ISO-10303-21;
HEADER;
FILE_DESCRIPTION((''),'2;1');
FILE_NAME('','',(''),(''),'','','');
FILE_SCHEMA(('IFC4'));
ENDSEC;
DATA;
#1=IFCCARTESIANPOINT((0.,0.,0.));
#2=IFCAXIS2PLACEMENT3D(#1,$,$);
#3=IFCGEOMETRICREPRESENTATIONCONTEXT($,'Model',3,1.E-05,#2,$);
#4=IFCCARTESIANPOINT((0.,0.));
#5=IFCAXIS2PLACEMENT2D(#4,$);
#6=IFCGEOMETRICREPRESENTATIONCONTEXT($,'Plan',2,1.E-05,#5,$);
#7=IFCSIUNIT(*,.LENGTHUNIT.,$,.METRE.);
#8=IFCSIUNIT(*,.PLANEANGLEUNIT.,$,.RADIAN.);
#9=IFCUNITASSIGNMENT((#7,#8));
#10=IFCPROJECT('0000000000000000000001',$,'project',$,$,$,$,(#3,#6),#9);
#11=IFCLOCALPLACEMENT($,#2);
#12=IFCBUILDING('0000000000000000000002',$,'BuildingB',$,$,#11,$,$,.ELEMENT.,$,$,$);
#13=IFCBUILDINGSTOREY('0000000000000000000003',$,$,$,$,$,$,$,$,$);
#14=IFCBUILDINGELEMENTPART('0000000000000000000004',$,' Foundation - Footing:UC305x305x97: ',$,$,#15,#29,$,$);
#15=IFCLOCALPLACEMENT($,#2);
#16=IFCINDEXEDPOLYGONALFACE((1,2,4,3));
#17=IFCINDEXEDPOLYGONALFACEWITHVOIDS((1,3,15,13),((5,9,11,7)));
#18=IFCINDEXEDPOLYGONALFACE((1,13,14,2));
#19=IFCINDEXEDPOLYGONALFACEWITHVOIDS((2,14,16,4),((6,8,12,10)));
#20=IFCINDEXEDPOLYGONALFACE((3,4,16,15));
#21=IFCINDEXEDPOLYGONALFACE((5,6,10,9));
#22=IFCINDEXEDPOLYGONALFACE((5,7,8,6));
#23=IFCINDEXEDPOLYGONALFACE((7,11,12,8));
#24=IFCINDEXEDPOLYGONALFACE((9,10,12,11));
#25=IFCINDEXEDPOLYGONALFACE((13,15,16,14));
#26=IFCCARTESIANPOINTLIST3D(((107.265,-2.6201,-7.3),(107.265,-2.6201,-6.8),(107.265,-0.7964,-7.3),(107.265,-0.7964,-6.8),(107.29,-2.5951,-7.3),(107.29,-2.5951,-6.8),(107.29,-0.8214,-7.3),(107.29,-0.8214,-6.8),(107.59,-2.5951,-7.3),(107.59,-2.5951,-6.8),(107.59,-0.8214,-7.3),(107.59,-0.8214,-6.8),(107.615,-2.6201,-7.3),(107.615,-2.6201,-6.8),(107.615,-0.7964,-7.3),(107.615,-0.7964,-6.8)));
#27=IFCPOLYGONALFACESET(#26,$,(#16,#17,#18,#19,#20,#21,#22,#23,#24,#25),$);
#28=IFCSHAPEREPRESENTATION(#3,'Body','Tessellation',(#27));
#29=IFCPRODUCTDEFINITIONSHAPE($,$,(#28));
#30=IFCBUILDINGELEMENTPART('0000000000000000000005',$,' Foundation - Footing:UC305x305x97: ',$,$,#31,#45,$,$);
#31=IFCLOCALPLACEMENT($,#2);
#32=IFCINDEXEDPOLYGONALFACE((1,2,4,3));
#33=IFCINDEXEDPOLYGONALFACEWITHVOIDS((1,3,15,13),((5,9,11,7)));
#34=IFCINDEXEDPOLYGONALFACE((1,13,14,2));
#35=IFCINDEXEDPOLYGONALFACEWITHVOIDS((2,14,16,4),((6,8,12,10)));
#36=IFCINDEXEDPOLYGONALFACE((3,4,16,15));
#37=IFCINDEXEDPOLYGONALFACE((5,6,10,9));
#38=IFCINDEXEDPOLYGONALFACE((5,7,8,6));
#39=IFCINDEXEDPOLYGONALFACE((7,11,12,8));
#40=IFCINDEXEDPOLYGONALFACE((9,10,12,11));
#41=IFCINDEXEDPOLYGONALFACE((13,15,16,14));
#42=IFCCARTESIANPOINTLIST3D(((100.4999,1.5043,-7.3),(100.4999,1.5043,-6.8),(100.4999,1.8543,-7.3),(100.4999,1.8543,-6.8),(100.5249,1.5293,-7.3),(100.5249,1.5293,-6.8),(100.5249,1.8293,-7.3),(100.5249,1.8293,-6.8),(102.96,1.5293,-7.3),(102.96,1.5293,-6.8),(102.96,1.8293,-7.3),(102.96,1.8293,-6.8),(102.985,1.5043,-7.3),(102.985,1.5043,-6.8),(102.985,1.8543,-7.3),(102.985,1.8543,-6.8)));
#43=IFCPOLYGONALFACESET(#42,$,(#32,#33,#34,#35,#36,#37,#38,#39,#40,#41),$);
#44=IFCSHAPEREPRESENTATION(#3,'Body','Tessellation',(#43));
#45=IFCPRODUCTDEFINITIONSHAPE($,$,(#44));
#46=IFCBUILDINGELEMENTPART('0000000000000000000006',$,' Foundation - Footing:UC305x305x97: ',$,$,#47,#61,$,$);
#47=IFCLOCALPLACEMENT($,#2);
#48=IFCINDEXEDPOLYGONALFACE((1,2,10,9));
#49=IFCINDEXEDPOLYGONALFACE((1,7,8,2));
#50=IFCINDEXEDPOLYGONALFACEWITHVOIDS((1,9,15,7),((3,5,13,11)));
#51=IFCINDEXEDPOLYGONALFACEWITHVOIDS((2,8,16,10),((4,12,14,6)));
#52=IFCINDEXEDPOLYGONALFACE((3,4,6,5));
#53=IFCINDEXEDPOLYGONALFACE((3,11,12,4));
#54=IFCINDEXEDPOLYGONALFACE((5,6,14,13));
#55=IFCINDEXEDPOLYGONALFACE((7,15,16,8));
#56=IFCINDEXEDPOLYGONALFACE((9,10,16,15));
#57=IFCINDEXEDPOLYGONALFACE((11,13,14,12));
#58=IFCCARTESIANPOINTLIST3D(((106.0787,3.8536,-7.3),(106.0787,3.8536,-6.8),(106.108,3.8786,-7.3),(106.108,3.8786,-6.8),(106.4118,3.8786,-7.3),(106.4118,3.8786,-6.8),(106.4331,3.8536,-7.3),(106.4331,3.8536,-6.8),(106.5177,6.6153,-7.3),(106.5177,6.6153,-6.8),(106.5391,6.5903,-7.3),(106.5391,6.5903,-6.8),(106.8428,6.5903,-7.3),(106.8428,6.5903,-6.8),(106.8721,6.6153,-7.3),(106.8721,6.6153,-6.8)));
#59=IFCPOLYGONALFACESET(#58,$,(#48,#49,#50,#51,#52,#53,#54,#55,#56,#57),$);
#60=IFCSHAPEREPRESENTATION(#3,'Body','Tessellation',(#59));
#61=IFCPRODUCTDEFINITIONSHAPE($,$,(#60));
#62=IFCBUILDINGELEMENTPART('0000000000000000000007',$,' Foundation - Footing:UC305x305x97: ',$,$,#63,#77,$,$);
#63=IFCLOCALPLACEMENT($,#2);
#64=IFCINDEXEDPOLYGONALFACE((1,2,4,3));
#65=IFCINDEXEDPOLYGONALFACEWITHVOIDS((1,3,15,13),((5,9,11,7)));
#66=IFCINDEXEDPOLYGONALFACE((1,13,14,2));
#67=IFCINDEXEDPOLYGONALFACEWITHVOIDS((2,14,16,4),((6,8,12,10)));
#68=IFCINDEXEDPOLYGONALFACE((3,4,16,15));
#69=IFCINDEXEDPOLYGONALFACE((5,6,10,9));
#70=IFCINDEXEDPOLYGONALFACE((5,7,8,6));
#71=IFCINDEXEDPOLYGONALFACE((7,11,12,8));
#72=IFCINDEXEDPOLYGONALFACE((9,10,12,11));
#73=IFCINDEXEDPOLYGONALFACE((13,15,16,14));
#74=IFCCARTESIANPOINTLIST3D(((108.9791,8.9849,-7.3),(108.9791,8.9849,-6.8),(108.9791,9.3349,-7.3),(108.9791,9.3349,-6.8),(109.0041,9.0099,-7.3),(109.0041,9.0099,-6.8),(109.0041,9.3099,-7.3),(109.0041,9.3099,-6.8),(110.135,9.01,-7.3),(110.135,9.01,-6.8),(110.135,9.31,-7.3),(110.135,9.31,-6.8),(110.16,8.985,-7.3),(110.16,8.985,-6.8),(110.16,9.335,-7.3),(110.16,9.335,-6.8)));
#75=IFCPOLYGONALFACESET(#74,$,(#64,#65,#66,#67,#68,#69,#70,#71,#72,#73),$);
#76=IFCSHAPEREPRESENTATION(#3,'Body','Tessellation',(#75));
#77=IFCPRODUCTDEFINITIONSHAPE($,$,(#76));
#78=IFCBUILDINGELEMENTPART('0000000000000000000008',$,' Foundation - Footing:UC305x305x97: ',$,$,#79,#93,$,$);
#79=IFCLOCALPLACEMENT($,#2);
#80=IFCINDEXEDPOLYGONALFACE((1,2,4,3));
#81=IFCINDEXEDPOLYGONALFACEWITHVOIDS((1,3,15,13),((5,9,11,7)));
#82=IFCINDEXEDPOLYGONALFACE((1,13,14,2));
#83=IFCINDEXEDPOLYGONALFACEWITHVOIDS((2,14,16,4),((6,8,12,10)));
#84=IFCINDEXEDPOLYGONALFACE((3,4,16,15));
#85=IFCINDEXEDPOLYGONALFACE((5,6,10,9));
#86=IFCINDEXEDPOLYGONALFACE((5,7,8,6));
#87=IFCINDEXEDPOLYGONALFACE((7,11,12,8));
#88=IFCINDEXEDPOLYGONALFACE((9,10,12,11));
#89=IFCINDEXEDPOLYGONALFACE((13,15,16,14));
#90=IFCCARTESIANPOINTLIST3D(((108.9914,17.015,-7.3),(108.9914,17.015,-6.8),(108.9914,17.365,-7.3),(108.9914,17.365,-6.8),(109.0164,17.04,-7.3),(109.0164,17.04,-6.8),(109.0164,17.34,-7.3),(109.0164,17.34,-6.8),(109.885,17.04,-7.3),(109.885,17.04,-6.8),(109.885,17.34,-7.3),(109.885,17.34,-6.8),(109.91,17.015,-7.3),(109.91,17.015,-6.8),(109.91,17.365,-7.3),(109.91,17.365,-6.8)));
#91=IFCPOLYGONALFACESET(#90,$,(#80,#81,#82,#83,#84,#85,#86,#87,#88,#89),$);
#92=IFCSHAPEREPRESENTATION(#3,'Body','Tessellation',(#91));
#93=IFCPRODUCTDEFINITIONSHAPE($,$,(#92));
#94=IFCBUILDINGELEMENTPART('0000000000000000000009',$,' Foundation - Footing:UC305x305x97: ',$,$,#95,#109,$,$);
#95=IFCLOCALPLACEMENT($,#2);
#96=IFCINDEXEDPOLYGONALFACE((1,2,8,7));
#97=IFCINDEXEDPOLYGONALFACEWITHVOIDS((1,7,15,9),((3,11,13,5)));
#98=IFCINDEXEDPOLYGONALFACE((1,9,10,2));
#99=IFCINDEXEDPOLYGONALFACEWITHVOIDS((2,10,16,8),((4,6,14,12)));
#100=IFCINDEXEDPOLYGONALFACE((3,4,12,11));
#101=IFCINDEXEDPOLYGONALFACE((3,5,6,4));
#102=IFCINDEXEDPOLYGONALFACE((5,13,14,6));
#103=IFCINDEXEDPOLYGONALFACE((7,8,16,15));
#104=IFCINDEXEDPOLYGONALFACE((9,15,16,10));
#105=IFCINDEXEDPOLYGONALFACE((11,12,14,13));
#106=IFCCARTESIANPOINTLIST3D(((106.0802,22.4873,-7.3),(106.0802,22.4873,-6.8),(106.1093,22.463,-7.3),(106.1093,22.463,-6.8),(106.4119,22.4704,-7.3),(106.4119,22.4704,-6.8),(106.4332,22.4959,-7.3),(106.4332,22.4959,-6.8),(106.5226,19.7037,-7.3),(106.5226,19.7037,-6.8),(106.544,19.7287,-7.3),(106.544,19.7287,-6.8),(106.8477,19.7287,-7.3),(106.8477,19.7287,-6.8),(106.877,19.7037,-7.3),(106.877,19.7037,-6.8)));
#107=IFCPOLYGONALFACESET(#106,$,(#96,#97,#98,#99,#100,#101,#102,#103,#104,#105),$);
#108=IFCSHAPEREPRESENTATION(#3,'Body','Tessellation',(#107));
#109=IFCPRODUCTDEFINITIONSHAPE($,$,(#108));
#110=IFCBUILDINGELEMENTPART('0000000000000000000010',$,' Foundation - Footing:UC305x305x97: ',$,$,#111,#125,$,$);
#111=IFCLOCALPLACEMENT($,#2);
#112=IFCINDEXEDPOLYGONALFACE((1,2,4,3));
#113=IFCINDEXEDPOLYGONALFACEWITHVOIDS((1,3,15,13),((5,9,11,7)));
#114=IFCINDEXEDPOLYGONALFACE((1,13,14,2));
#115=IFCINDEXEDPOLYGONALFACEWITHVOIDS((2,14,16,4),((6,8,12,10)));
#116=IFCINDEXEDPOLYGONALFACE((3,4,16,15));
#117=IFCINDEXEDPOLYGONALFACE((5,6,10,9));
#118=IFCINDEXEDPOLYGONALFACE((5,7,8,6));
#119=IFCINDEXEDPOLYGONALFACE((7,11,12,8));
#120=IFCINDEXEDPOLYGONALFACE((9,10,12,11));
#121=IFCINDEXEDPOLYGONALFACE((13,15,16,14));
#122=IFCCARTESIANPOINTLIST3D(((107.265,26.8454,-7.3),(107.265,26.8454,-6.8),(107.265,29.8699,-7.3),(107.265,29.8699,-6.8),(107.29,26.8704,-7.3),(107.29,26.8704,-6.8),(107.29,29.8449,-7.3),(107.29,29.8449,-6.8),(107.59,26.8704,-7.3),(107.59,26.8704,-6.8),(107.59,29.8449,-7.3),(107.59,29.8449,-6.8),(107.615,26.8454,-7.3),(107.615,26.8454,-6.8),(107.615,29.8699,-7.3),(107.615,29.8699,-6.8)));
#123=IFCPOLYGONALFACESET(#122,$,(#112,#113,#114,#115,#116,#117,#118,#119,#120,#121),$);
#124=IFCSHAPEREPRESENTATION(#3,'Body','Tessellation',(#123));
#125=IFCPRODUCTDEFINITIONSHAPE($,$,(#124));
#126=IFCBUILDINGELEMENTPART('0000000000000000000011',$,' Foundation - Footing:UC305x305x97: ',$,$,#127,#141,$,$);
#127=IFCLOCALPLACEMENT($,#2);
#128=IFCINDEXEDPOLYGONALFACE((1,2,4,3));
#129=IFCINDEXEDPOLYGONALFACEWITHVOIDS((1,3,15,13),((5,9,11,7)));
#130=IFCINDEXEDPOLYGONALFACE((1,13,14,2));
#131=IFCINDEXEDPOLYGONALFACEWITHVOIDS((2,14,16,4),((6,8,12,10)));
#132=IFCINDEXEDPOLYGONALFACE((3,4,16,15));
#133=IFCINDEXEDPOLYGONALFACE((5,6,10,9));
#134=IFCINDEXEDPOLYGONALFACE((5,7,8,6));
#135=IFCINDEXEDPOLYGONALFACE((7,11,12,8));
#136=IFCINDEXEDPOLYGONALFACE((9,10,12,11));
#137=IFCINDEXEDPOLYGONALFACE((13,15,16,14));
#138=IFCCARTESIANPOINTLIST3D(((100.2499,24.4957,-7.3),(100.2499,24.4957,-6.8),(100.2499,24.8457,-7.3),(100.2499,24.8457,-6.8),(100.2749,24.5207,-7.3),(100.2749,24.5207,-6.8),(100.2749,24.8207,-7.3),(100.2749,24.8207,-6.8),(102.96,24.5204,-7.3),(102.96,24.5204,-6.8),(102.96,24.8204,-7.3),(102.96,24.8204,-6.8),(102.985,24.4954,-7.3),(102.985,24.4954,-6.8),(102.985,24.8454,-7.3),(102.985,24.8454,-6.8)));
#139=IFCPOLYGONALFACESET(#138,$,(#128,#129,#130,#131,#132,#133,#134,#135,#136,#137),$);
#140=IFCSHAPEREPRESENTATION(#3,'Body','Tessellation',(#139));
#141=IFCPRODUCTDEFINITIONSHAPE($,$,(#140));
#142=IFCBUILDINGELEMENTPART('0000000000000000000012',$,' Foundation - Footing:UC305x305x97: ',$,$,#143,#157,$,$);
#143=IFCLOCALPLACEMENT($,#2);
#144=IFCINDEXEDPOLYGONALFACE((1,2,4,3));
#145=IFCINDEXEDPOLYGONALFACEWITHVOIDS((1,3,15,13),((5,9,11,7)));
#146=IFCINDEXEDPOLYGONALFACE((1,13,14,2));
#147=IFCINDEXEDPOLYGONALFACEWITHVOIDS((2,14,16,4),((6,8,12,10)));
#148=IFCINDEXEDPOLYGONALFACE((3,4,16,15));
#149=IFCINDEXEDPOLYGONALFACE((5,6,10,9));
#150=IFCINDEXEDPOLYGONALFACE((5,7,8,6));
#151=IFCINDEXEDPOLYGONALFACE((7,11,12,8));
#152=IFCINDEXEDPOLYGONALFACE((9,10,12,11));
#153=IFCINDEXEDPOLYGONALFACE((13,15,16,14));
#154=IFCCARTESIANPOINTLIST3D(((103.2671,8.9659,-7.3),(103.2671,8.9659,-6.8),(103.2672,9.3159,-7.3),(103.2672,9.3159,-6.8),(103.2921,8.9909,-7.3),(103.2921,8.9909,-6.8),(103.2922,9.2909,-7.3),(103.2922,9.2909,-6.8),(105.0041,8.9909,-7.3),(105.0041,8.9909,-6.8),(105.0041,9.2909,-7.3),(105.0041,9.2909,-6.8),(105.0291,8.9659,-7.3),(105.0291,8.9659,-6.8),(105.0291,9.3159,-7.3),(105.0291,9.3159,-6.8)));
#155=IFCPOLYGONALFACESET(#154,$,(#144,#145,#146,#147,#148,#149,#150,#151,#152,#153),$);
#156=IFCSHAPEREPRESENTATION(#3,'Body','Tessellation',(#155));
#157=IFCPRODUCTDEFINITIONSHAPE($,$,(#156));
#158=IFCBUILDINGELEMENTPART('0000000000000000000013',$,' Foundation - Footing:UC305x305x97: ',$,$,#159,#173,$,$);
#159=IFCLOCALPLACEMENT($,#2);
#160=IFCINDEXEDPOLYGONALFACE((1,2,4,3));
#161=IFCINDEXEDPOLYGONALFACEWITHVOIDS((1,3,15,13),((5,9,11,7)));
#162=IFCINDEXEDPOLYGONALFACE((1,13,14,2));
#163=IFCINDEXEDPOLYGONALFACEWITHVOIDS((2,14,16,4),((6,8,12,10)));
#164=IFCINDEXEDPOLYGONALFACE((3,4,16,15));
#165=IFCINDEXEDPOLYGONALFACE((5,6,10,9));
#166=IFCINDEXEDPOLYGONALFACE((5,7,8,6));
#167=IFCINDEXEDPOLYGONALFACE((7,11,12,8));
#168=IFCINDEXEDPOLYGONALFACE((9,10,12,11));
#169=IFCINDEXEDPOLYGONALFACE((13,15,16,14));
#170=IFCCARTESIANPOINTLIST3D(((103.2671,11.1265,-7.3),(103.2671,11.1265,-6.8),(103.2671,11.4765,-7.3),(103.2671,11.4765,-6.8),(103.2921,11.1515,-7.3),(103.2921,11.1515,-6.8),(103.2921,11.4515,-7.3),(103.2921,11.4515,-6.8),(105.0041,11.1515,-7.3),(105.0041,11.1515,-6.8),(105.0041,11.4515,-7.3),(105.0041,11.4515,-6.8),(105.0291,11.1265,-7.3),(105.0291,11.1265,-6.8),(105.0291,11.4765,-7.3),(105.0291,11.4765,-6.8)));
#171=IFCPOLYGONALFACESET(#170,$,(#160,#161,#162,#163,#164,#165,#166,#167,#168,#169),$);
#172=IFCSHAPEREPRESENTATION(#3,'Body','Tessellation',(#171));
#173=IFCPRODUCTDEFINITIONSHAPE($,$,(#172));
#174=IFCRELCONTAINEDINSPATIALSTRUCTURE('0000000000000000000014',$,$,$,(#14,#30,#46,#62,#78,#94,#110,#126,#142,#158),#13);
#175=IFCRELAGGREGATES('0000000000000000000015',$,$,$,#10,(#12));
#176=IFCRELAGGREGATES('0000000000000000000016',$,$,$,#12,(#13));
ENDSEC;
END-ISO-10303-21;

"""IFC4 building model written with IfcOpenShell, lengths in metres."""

from ifc_helpers import new_model, si_unit, origin, origin_2d, place, context, project, spatial, polyline, outline, extrude, element, save


model = new_model("IFC4")

# Units and contexts
model_context = context("Model", 3, precision=1e-05, world=origin())
plan_context = context("Plan", 2, precision=1e-05, world=origin_2d())
ifc_project = project(units=[si_unit("LENGTHUNIT", "METRE"), si_unit("PLANEANGLEUNIT", "RADIAN")], contexts=[model_context, plan_context])

# Building, storey
building_placement = place(None, origin())
building = spatial("IfcBuilding", under=ifc_project, at=building_placement, Name="BuildingB", CompositionType="ELEMENT")
storey = spatial("IfcBuildingStorey", under=building)

# Building element parts, openings
building_element_part_1 = element("IfcBuildingElementPart", 1, inside=storey, Name=" Foundation - Footing:UC305x305x97: ", context=model_context, shape_type="SweptSolid", body=[
    extrude(outline(polyline([(107.615, -2.6201, -7.3), (107.265, -2.6201, -7.3), (107.265, -0.7964, -7.3), (107.615, -0.7964, -7.3), (107.615, -2.6201, -7.3)])), None, (0.0, 0.0, 1.0), 0.5),
])
element("IfcOpeningElement", 2, inside=storey, cuts=building_element_part_1, context=model_context, shape_type="SweptSolid", body=[
    extrude(outline(polyline([(107.59, -2.5951, -7.3), (107.29, -2.5951, -7.3), (107.29, -0.8214, -7.3), (107.59, -0.8214, -7.3), (107.59, -2.5951, -7.3)])), None, (0.0, 0.0, 1.0), 0.5),
])
building_element_part_2 = element("IfcBuildingElementPart", 3, inside=storey, Name=" Foundation - Footing:UC305x305x97: ", context=model_context, shape_type="SweptSolid", body=[
    extrude(outline(polyline([(102.985, 1.5043, -7.3), (102.985, 1.8543, -7.3), (100.4999, 1.8543, -7.3), (100.4999, 1.5043, -7.3), (102.985, 1.5043, -7.3)])), None, (0.0, 0.0, 1.0), 0.5),
])
element("IfcOpeningElement", 4, inside=storey, cuts=building_element_part_2, context=model_context, shape_type="SweptSolid", body=[
    extrude(outline(polyline([(102.96, 1.5293, -7.3), (102.96, 1.8293, -7.3), (100.5249, 1.8293, -7.3), (100.5249, 1.5293, -7.3), (102.96, 1.5293, -7.3)])), None, (0.0, 0.0, 1.0), 0.5),
])
building_element_part_3 = element("IfcBuildingElementPart", 5, inside=storey, Name=" Foundation - Footing:UC305x305x97: ", context=model_context, shape_type="SweptSolid", body=[
    extrude(outline(polyline([(106.4331, 3.8536, -7.3), (106.8721, 6.6153, -7.3), (106.5177, 6.6153, -7.3), (106.0787, 3.8536, -7.3), (106.4331, 3.8536, -7.3)])), None, (0.0, 0.0, 1.0), 0.5),
])
element("IfcOpeningElement", 6, inside=storey, cuts=building_element_part_3, context=model_context, shape_type="SweptSolid", body=[
    extrude(outline(polyline([(106.4118, 3.8786, -7.3), (106.8428, 6.5903, -7.3), (106.5391, 6.5903, -7.3), (106.108, 3.8786, -7.3), (106.4118, 3.8786, -7.3)])), None, (0.0, 0.0, 1.0), 0.5),
])
building_element_part_4 = element("IfcBuildingElementPart", 7, inside=storey, Name=" Foundation - Footing:UC305x305x97: ", context=model_context, shape_type="SweptSolid", body=[
    extrude(outline(polyline([(110.16, 8.985, -7.3), (110.16, 9.335, -7.3), (108.9791, 9.3349, -7.3), (108.9791, 8.9849, -7.3), (110.16, 8.985, -7.3)])), None, (0.0, 0.0, 1.0), 0.5),
])
element("IfcOpeningElement", 8, inside=storey, cuts=building_element_part_4, context=model_context, shape_type="SweptSolid", body=[
    extrude(outline(polyline([(110.135, 9.01, -7.3), (110.135, 9.31, -7.3), (109.0041, 9.3099, -7.3), (109.0041, 9.0099, -7.3), (110.135, 9.01, -7.3)])), None, (0.0, 0.0, 1.0), 0.5),
])
building_element_part_5 = element("IfcBuildingElementPart", 9, inside=storey, Name=" Foundation - Footing:UC305x305x97: ", context=model_context, shape_type="SweptSolid", body=[
    extrude(outline(polyline([(109.91, 17.015, -7.3), (109.91, 17.365, -7.3), (108.9914, 17.365, -7.3), (108.9914, 17.015, -7.3), (109.91, 17.015, -7.3)])), None, (0.0, 0.0, 1.0), 0.5),
])
element("IfcOpeningElement", 10, inside=storey, cuts=building_element_part_5, context=model_context, shape_type="SweptSolid", body=[
    extrude(outline(polyline([(109.885, 17.04, -7.3), (109.885, 17.34, -7.3), (109.0164, 17.34, -7.3), (109.0164, 17.04, -7.3), (109.885, 17.04, -7.3)])), None, (0.0, 0.0, 1.0), 0.5),
])
building_element_part_6 = element("IfcBuildingElementPart", 11, inside=storey, Name=" Foundation - Footing:UC305x305x97: ", context=model_context, shape_type="SweptSolid", body=[
    extrude(outline(polyline([(106.5226, 19.7037, -7.3), (106.877, 19.7037, -7.3), (106.4332, 22.4959, -7.3), (106.0802, 22.4873, -7.3), (106.5226, 19.7037, -7.3)])), None, (0.0, 0.0, 1.0), 0.5),
])
element("IfcOpeningElement", 12, inside=storey, cuts=building_element_part_6, context=model_context, shape_type="SweptSolid", body=[
    extrude(outline(polyline([(106.544, 19.7287, -7.3), (106.8477, 19.7287, -7.3), (106.4119, 22.4704, -7.3), (106.1093, 22.463, -7.3), (106.544, 19.7287, -7.3)])), None, (0.0, 0.0, 1.0), 0.5),
])
building_element_part_7 = element("IfcBuildingElementPart", 13, inside=storey, Name=" Foundation - Footing:UC305x305x97: ", context=model_context, shape_type="SweptSolid", body=[
    extrude(outline(polyline([(107.265, 26.8454, -7.3), (107.615, 26.8454, -7.3), (107.615, 29.8699, -7.3), (107.265, 29.8699, -7.3), (107.265, 26.8454, -7.3)])), None, (0.0, 0.0, 1.0), 0.5),
])
element("IfcOpeningElement", 14, inside=storey, cuts=building_element_part_7, context=model_context, shape_type="SweptSolid", body=[
    extrude(outline(polyline([(107.29, 26.8704, -7.3), (107.59, 26.8704, -7.3), (107.59, 29.8449, -7.3), (107.29, 29.8449, -7.3), (107.29, 26.8704, -7.3)])), None, (0.0, 0.0, 1.0), 0.5),
])
building_element_part_8 = element("IfcBuildingElementPart", 15, inside=storey, Name=" Foundation - Footing:UC305x305x97: ", context=model_context, shape_type="SweptSolid", body=[
    extrude(outline(polyline([(102.985, 24.4954, -7.3), (102.985, 24.8454, -7.3), (100.2499, 24.8457, -7.3), (100.2499, 24.4957, -7.3), (102.985, 24.4954, -7.3)])), None, (0.0, 0.0, 1.0), 0.5),
])
element("IfcOpeningElement", 16, inside=storey, cuts=building_element_part_8, context=model_context, shape_type="SweptSolid", body=[
    extrude(outline(polyline([(102.96, 24.5204, -7.3), (102.96, 24.8204, -7.3), (100.2749, 24.8207, -7.3), (100.2749, 24.5207, -7.3), (102.96, 24.5204, -7.3)])), None, (0.0, 0.0, 1.0), 0.5),
])
building_element_part_9 = element("IfcBuildingElementPart", 17, inside=storey, Name=" Foundation - Footing:UC305x305x97: ", context=model_context, shape_type="SweptSolid", body=[
    extrude(outline(polyline([(105.0291, 8.9659, -7.3), (105.0291, 9.3159, -7.3), (103.2672, 9.3159, -7.3), (103.2671, 8.9659, -7.3), (105.0291, 8.9659, -7.3)])), None, (0.0, 0.0, 1.0), 0.5),
])
element("IfcOpeningElement", 18, inside=storey, cuts=building_element_part_9, context=model_context, shape_type="SweptSolid", body=[
    extrude(outline(polyline([(105.0041, 8.9909, -7.3), (105.0041, 9.2909, -7.3), (103.2922, 9.2909, -7.3), (103.2921, 8.9909, -7.3), (105.0041, 8.9909, -7.3)])), None, (0.0, 0.0, 1.0), 0.5),
])
building_element_part_10 = element("IfcBuildingElementPart", 19, inside=storey, Name=" Foundation - Footing:UC305x305x97: ", context=model_context, shape_type="SweptSolid", body=[
    extrude(outline(polyline([(105.0291, 11.1265, -7.3), (105.0291, 11.4765, -7.3), (103.2671, 11.4765, -7.3), (103.2671, 11.1265, -7.3), (105.0291, 11.1265, -7.3)])), None, (0.0, 0.0, 1.0), 0.5),
])
element("IfcOpeningElement", 20, inside=storey, cuts=building_element_part_10, context=model_context, shape_type="SweptSolid", body=[
    extrude(outline(polyline([(105.0041, 11.1515, -7.3), (105.0041, 11.4515, -7.3), (103.2921, 11.4515, -7.3), (103.2921, 11.1515, -7.3), (105.0041, 11.1515, -7.3)])), None, (0.0, 0.0, 1.0), 0.5),
])

save(model, "model.ifc")
